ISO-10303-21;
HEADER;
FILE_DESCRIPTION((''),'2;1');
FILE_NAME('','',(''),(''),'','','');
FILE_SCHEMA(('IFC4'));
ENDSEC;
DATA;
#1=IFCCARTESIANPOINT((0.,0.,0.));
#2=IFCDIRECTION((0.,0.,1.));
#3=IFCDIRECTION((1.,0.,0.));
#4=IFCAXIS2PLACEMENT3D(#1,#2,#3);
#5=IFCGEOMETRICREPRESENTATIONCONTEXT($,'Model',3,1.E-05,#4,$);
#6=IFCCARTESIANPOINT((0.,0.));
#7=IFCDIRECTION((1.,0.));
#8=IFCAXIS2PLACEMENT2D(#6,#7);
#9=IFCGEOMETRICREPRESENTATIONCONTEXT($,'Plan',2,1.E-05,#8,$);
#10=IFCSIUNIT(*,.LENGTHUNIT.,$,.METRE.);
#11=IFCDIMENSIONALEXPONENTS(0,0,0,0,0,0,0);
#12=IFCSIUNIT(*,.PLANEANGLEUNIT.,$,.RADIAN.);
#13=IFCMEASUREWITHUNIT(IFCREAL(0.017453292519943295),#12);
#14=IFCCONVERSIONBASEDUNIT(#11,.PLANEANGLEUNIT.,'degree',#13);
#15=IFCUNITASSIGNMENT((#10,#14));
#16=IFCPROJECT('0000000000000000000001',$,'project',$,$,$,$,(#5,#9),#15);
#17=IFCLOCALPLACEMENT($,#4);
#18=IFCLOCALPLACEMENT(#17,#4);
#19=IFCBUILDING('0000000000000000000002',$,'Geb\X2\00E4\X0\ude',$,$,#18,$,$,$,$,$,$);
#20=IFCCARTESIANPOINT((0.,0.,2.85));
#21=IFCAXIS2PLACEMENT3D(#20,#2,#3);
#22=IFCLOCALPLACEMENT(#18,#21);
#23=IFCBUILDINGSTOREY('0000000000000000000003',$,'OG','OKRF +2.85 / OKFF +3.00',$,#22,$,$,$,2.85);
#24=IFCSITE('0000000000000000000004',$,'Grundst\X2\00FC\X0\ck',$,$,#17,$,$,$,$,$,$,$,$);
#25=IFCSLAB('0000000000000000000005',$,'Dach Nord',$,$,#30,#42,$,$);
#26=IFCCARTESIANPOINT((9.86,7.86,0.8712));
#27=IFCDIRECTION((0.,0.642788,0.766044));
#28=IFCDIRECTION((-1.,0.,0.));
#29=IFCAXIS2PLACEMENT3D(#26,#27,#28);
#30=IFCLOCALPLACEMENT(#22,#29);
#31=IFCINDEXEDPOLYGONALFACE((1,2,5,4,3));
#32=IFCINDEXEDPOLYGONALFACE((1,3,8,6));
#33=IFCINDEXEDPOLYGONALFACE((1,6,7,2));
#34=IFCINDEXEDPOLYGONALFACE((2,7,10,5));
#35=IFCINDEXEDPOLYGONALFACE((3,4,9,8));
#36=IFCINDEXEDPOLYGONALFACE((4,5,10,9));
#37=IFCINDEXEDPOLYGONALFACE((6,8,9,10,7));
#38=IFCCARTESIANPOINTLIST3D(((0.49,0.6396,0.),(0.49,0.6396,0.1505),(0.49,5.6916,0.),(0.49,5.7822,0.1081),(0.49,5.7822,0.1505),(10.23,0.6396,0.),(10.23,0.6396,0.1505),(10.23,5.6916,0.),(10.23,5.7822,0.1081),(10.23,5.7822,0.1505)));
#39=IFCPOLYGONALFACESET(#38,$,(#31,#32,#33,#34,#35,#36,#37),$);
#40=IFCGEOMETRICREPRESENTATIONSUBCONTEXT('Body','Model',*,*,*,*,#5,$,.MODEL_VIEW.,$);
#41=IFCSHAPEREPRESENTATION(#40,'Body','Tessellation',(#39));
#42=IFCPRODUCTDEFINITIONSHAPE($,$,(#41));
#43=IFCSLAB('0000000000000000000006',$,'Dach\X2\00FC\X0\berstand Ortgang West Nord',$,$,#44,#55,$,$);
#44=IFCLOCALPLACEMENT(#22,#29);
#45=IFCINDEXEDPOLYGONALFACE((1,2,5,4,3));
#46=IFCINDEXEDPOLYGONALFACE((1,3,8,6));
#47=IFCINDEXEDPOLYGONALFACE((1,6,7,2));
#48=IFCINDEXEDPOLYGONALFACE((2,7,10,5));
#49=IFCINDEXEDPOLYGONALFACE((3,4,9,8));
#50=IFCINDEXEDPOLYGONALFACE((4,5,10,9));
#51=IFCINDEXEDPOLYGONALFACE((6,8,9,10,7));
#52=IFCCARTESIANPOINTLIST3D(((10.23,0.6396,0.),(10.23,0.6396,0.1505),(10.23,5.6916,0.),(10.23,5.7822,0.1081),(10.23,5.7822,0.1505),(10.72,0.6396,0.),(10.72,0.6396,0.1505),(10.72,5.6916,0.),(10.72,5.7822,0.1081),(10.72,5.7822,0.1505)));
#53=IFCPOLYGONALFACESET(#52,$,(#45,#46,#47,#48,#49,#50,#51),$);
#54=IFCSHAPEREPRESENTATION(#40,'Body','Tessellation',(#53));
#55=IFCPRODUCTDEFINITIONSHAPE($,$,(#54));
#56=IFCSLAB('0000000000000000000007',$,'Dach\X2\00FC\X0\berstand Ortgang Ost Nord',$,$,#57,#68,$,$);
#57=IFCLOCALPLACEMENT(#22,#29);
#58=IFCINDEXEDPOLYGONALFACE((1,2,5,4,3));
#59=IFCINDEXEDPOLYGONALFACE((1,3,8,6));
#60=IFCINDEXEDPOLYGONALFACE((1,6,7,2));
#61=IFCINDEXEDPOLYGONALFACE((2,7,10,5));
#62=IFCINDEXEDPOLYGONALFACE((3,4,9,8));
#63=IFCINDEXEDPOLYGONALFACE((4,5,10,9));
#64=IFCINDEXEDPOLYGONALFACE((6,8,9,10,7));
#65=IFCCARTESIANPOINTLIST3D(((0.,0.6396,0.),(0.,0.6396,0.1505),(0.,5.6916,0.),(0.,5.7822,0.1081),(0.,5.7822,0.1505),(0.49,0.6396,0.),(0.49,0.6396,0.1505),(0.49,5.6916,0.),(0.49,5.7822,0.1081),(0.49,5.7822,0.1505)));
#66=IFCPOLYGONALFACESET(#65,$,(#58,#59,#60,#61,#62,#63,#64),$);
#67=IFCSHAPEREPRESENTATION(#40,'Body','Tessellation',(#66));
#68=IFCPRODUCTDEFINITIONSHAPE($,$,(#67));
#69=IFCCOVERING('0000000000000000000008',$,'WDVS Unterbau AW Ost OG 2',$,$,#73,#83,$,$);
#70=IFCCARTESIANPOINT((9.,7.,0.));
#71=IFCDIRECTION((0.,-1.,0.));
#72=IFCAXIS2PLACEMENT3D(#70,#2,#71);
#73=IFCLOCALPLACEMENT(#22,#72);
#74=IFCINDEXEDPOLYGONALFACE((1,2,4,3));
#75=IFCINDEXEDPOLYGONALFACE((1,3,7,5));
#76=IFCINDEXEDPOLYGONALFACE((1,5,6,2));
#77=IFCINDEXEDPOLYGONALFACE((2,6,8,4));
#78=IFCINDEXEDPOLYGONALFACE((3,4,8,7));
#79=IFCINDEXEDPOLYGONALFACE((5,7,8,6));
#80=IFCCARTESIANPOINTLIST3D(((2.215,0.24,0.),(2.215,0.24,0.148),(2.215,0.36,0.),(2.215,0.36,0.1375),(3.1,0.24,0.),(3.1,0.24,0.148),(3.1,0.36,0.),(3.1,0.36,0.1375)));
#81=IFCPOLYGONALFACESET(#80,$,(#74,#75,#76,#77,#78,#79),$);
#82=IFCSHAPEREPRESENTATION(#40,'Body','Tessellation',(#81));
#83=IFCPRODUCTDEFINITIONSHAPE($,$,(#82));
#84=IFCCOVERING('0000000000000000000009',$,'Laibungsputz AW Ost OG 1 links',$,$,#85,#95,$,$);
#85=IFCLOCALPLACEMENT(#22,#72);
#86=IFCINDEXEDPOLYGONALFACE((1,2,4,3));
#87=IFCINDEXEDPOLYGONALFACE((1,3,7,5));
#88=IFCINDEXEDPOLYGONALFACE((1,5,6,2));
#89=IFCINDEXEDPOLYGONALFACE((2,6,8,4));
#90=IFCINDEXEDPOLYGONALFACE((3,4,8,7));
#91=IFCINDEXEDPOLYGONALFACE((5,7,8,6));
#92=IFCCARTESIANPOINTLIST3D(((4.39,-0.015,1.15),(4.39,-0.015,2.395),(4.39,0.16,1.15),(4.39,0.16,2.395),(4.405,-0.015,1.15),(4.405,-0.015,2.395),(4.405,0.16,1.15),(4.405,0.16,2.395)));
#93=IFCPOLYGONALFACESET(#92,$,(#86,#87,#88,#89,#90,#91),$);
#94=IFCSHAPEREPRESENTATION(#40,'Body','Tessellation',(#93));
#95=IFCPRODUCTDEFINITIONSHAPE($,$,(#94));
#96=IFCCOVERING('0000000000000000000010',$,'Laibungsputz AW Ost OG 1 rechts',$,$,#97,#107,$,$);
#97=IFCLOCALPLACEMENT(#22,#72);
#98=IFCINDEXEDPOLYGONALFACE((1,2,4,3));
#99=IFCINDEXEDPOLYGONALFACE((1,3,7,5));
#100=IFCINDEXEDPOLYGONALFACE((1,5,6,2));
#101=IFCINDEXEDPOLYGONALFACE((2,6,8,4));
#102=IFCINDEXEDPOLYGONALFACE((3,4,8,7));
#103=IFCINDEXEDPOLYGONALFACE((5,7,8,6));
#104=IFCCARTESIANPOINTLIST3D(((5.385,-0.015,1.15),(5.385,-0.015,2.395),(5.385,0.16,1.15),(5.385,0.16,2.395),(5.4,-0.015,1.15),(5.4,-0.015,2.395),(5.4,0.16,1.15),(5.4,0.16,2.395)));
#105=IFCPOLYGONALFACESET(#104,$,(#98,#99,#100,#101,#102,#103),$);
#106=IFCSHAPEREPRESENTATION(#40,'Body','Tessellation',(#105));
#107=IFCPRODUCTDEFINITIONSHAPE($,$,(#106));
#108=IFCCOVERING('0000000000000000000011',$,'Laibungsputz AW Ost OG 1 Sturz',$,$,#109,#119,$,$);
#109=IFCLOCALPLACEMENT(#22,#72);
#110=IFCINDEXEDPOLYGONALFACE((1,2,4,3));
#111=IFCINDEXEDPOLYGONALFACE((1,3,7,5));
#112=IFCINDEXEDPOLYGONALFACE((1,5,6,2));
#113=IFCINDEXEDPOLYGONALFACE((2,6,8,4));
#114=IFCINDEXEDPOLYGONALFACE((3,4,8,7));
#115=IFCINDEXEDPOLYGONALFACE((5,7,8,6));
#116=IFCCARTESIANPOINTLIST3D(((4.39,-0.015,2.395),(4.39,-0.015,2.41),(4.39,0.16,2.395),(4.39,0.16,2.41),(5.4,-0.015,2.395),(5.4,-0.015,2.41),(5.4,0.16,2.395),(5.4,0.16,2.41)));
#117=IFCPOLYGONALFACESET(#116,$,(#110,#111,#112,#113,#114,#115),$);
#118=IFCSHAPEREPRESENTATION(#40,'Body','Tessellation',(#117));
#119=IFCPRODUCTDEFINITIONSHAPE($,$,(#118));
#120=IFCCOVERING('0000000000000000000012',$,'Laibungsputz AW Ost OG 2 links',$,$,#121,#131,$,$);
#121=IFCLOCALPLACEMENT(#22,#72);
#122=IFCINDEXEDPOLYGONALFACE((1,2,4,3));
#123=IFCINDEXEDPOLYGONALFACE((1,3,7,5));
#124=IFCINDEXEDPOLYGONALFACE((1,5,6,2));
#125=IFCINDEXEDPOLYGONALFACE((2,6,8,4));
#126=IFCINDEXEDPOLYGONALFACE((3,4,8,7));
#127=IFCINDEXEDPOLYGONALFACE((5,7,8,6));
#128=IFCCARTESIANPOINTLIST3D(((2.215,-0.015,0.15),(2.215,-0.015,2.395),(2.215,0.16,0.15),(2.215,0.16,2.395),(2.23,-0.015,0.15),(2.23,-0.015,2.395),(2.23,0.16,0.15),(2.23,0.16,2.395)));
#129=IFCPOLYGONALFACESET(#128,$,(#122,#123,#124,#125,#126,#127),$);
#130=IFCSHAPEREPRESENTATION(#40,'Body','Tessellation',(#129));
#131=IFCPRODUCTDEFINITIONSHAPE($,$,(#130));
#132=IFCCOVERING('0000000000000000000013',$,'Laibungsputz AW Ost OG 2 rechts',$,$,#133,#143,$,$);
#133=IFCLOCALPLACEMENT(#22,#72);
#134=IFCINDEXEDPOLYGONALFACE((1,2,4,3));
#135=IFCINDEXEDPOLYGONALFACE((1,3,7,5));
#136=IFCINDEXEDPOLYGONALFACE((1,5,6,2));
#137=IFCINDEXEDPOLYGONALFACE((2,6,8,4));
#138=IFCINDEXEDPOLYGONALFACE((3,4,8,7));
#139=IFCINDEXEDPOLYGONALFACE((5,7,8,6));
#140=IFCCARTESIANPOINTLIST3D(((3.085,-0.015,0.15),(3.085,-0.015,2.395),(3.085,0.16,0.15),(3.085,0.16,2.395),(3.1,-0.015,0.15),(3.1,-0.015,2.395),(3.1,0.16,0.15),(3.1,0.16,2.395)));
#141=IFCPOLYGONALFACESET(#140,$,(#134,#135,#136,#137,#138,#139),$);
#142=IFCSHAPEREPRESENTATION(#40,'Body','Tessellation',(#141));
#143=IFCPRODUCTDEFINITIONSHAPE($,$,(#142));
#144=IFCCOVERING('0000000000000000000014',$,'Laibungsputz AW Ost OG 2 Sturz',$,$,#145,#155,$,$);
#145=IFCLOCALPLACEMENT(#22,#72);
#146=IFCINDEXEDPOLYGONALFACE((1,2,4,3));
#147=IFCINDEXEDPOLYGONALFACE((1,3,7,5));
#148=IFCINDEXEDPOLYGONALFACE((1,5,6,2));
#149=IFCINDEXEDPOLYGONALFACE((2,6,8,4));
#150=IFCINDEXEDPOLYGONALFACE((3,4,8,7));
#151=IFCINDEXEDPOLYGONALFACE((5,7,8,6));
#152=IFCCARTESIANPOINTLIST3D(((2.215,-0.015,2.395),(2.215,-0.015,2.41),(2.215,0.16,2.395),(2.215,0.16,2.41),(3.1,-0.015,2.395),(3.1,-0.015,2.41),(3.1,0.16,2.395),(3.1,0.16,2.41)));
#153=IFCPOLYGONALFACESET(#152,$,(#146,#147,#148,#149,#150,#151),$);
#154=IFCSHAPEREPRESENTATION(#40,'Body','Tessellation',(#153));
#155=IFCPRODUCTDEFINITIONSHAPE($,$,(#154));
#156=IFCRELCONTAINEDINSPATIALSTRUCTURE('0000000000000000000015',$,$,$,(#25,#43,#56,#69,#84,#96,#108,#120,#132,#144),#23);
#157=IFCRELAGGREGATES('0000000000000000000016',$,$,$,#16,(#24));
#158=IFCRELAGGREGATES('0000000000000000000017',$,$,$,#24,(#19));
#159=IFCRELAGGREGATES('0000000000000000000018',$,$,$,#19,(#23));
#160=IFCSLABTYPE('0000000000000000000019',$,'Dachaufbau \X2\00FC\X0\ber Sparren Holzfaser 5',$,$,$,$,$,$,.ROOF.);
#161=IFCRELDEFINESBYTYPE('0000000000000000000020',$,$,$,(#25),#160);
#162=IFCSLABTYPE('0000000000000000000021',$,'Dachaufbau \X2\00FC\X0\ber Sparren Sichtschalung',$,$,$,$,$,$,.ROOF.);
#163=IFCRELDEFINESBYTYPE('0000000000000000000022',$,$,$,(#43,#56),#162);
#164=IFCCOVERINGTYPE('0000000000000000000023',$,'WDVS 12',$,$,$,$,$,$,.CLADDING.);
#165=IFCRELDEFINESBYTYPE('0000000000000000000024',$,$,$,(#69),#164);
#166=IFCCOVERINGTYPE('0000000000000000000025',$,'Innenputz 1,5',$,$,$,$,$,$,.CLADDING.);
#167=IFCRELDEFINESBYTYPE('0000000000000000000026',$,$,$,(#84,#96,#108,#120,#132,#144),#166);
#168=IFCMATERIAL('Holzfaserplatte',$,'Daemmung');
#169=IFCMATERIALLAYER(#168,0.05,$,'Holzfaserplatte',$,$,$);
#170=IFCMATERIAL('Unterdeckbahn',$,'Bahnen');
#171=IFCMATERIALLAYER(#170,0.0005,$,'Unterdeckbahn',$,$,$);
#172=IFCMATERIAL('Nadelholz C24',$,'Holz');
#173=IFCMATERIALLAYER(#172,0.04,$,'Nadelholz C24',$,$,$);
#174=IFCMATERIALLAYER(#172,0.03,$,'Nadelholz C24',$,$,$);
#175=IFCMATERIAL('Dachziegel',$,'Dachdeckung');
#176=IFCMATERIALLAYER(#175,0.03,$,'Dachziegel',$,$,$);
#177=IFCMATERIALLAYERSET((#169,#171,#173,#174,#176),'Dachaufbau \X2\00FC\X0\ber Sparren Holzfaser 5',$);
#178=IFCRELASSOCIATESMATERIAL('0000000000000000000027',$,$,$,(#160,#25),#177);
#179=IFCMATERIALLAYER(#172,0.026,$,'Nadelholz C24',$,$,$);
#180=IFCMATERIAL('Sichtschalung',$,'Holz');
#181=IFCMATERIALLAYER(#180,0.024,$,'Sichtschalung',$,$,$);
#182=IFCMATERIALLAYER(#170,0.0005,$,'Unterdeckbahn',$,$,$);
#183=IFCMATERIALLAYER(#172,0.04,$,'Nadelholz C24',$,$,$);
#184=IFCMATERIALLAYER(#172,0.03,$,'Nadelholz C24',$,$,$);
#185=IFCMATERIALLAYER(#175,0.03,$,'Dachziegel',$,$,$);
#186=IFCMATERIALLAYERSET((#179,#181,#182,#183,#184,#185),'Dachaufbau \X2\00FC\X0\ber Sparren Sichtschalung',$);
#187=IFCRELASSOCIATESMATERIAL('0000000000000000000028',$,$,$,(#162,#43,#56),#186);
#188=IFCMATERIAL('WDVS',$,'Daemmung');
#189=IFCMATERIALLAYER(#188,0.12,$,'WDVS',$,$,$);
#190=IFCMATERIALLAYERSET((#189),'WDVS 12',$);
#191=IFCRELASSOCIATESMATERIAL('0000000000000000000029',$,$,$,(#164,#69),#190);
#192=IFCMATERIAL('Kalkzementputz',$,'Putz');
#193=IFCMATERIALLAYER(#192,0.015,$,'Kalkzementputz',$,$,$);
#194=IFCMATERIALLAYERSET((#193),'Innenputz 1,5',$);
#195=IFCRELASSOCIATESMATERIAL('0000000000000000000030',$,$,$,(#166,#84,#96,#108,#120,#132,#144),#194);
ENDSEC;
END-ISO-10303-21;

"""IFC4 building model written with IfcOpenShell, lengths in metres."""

from ifc_helpers import new_model, entity, si_unit, converted_unit, frame, origin_with_axes, origin_2d_with_axis, place, context, subcontext, project, spatial, polyline, indexed_curve, outline, extrude, clip, halfspace, material, layer, layer_set, layer_usage, type_object, element, save


model = new_model("IFC4")

# Units and contexts
model_context = context("Model", 3, precision=1e-05, world=origin_with_axes())
plan_context = context("Plan", 2, precision=1e-05, world=origin_2d_with_axis())
body_context = subcontext(model_context, "Body", "Model", "MODEL_VIEW")
ifc_project = project(units=[si_unit("LENGTHUNIT", "METRE"), converted_unit("PLANEANGLEUNIT", "degree", entity("IfcReal", 0.017453292519943295), si_unit("PLANEANGLEUNIT", "RADIAN"), dimensions=[0, 0, 0, 0, 0, 0, 0])], contexts=[model_context, plan_context])

# Site, building, storey
site_placement = place(None, origin_with_axes())
site = spatial("IfcSite", under=ifc_project, at=site_placement, Name="Grundstück")
building_placement = place(site_placement, origin_with_axes())
building = spatial("IfcBuilding", under=site, at=building_placement, Name="Gebäude")
storey_placement = place(building_placement, frame((0.0, 0.0, 2.85), z_axis=(0.0, 0.0, 1.0), x_axis=(1.0, 0.0, 0.0)))
storey = spatial("IfcBuildingStorey", under=building, at=storey_placement, Name="OG", Description="OKRF +2.85 / OKFF +3.00", Elevation=2.85)

# Shared definitions
ifc_material_1 = material(Name="Nadelholz C24", Category="Holz")

# Slabs
ifc_material_2 = material(Name="Holzfaserplatte", Category="Daemmung")
ifc_layer_1 = layer(ifc_material_2, 0.05, Name="Holzfaserplatte")
ifc_material_3 = material(Name="Unterdeckbahn", Category="Bahnen")
ifc_layer_2 = layer(ifc_material_3, 0.0005, Name="Unterdeckbahn")
ifc_layer_3 = layer(ifc_material_1, 0.04, Name="Nadelholz C24")
ifc_layer_4 = layer(ifc_material_1, 0.03, Name="Nadelholz C24")
ifc_material_4 = material(Name="Dachziegel", Category="Dachdeckung")
ifc_layer_5 = layer(ifc_material_4, 0.03, Name="Dachziegel")
ifc_layer_set_1 = layer_set([ifc_layer_1, ifc_layer_2, ifc_layer_3, ifc_layer_4, ifc_layer_5], Name="Dachaufbau über Sparren Holzfaser 5")
ifc_layer_usage_1 = layer_usage(ifc_layer_set_1, "AXIS3", "POSITIVE", 0.0)
slab_type_1 = type_object("IfcSlabType", Name="Dachaufbau über Sparren Holzfaser 5", PredefinedType="ROOF", material=ifc_layer_set_1)
slab_1_placement = place(storey_placement, frame((9.86, 7.86, 0.8712), z_axis=(0.0, 0.642788, 0.766044), x_axis=(-1.0, 0.0, 0.0)))
element("IfcSlab", 1, at=slab_1_placement, inside=storey, type_object=slab_type_1, material=ifc_layer_usage_1, Name="Dach Nord", context=body_context, shape_type="Clipping", body=[
    clip(extrude(outline(indexed_curve([(10.23, 5.7822), (0.49, 5.7822), (0.49, 0.6396), (10.23, 0.6396)])), None, (0.0, 0.0, 1.0), 0.1505), halfspace(frame((9.86, 0.948, -5.6532), z_axis=(0.0, 0.766044, -0.642788), x_axis=(1.0, 0.0, 0.0)), False)),
])
ifc_layer_6 = layer(ifc_material_1, 0.026, Name="Nadelholz C24")
ifc_material_5 = material(Name="Sichtschalung", Category="Holz")
ifc_layer_7 = layer(ifc_material_5, 0.024, Name="Sichtschalung")
ifc_layer_8 = layer(ifc_material_3, 0.0005, Name="Unterdeckbahn")
ifc_layer_9 = layer(ifc_material_1, 0.04, Name="Nadelholz C24")
ifc_layer_10 = layer(ifc_material_1, 0.03, Name="Nadelholz C24")
ifc_layer_11 = layer(ifc_material_4, 0.03, Name="Dachziegel")
ifc_layer_set_2 = layer_set([ifc_layer_6, ifc_layer_7, ifc_layer_8, ifc_layer_9, ifc_layer_10, ifc_layer_11], Name="Dachaufbau über Sparren Sichtschalung")
slab_type_2 = type_object("IfcSlabType", Name="Dachaufbau über Sparren Sichtschalung", PredefinedType="ROOF", material=ifc_layer_set_2)
ifc_layer_usage_2 = layer_usage(ifc_layer_set_2, "AXIS3", "POSITIVE", 0.0)
slab_2_placement = place(storey_placement, frame((9.86, 7.86, 0.8712), z_axis=(0.0, 0.642788, 0.766044), x_axis=(-1.0, 0.0, 0.0)))
element("IfcSlab", 2, at=slab_2_placement, inside=storey, type_object=slab_type_2, material=ifc_layer_usage_2, Name="Dachüberstand Ortgang West Nord", context=body_context, shape_type="Clipping", body=[
    clip(extrude(outline(indexed_curve([(10.72, 5.7822), (10.23, 5.7822), (10.23, 0.6396), (10.72, 0.6396)])), None, (0.0, 0.0, 1.0), 0.1505), halfspace(frame((9.86, 0.948, -5.6532), z_axis=(0.0, 0.766044, -0.642788), x_axis=(1.0, 0.0, 0.0)), False)),
])
ifc_layer_usage_3 = layer_usage(ifc_layer_set_2, "AXIS3", "POSITIVE", 0.0)
slab_3_placement = place(storey_placement, frame((9.86, 7.86, 0.8712), z_axis=(0.0, 0.642788, 0.766044), x_axis=(-1.0, 0.0, 0.0)))
element("IfcSlab", 3, at=slab_3_placement, inside=storey, type_object=slab_type_2, material=ifc_layer_usage_3, Name="Dachüberstand Ortgang Ost Nord", context=body_context, shape_type="Clipping", body=[
    clip(extrude(outline(indexed_curve([(0.49, 5.7822), (0.0, 5.7822), (0.0, 0.6396), (0.49, 0.6396)])), None, (0.0, 0.0, 1.0), 0.1505), halfspace(frame((9.86, 0.948, -5.6532), z_axis=(0.0, 0.766044, -0.642788), x_axis=(1.0, 0.0, 0.0)), False)),
])

# Coverings
ifc_material_6 = material(Name="WDVS", Category="Daemmung")
ifc_layer_12 = layer(ifc_material_6, 0.12, Name="WDVS")
ifc_layer_set_3 = layer_set([ifc_layer_12], Name="WDVS 12")
ifc_layer_usage_4 = layer_usage(ifc_layer_set_3, "AXIS2", "POSITIVE", 0.24)
covering_type_1 = type_object("IfcCoveringType", Name="WDVS 12", PredefinedType="CLADDING", material=ifc_layer_set_3)
covering_1_placement = place(storey_placement, frame((9.0, 7.0, 0.0), z_axis=(0.0, 0.0, 1.0), x_axis=(0.0, -1.0, 0.0)))
element("IfcCovering", 4, at=covering_1_placement, inside=storey, type_object=covering_type_1, material=ifc_layer_usage_4, Name="WDVS Unterbau AW Ost OG 2", context=body_context, shape_type="SweptSolid", body=[
    extrude(outline(polyline([(0.24, 0.0), (0.36, 0.0), (0.36, 0.1375), (0.24, 0.148), (0.24, 0.0)])), frame((2.215, 0.0, 0.0), z_axis=(1.0, 0.0, 0.0), x_axis=(0.0, 1.0, 0.0)), (0.0, 0.0, 1.0), 0.885),
])
ifc_material_7 = material(Name="Kalkzementputz", Category="Putz")
ifc_layer_13 = layer(ifc_material_7, 0.015, Name="Kalkzementputz")
ifc_layer_set_4 = layer_set([ifc_layer_13], Name="Innenputz 1,5")
ifc_layer_usage_5 = layer_usage(ifc_layer_set_4, "AXIS1", "POSITIVE", 4.39)
covering_type_2 = type_object("IfcCoveringType", Name="Innenputz 1,5", PredefinedType="CLADDING", material=ifc_layer_set_4)
covering_2_placement = place(storey_placement, frame((9.0, 7.0, 0.0), z_axis=(0.0, 0.0, 1.0), x_axis=(0.0, -1.0, 0.0)))
element("IfcCovering", 5, at=covering_2_placement, inside=storey, type_object=covering_type_2, material=ifc_layer_usage_5, Name="Laibungsputz AW Ost OG 1 links", context=body_context, shape_type="SweptSolid", body=[
    extrude(outline(polyline([(-0.015, 1.15), (0.16, 1.15), (0.16, 2.395), (-0.015, 2.395), (-0.015, 1.15)])), frame((4.39, 0.0, 0.0), z_axis=(1.0, 0.0, 0.0), x_axis=(0.0, 1.0, 0.0)), (0.0, 0.0, 1.0), 0.015),
])
ifc_layer_usage_6 = layer_usage(ifc_layer_set_4, "AXIS1", "POSITIVE", 5.385)
covering_3_placement = place(storey_placement, frame((9.0, 7.0, 0.0), z_axis=(0.0, 0.0, 1.0), x_axis=(0.0, -1.0, 0.0)))
element("IfcCovering", 6, at=covering_3_placement, inside=storey, type_object=covering_type_2, material=ifc_layer_usage_6, Name="Laibungsputz AW Ost OG 1 rechts", context=body_context, shape_type="SweptSolid", body=[
    extrude(outline(polyline([(-0.015, 1.15), (0.16, 1.15), (0.16, 2.395), (-0.015, 2.395), (-0.015, 1.15)])), frame((5.385, 0.0, 0.0), z_axis=(1.0, 0.0, 0.0), x_axis=(0.0, 1.0, 0.0)), (0.0, 0.0, 1.0), 0.015),
])
ifc_layer_usage_7 = layer_usage(ifc_layer_set_4, "AXIS3", "POSITIVE", 2.395)
covering_4_placement = place(storey_placement, frame((9.0, 7.0, 0.0), z_axis=(0.0, 0.0, 1.0), x_axis=(0.0, -1.0, 0.0)))
element("IfcCovering", 7, at=covering_4_placement, inside=storey, type_object=covering_type_2, material=ifc_layer_usage_7, Name="Laibungsputz AW Ost OG 1 Sturz", context=body_context, shape_type="SweptSolid", body=[
    extrude(outline(polyline([(-0.015, 2.395), (0.16, 2.395), (0.16, 2.41), (-0.015, 2.41), (-0.015, 2.395)])), frame((4.39, 0.0, 0.0), z_axis=(1.0, 0.0, 0.0), x_axis=(0.0, 1.0, 0.0)), (0.0, 0.0, 1.0), 1.01),
])
ifc_layer_usage_8 = layer_usage(ifc_layer_set_4, "AXIS1", "POSITIVE", 2.215)
covering_5_placement = place(storey_placement, frame((9.0, 7.0, 0.0), z_axis=(0.0, 0.0, 1.0), x_axis=(0.0, -1.0, 0.0)))
element("IfcCovering", 8, at=covering_5_placement, inside=storey, type_object=covering_type_2, material=ifc_layer_usage_8, Name="Laibungsputz AW Ost OG 2 links", context=body_context, shape_type="SweptSolid", body=[
    extrude(outline(polyline([(-0.015, 0.15), (0.16, 0.15), (0.16, 2.395), (-0.015, 2.395), (-0.015, 0.15)])), frame((2.215, 0.0, 0.0), z_axis=(1.0, 0.0, 0.0), x_axis=(0.0, 1.0, 0.0)), (0.0, 0.0, 1.0), 0.015),
])
ifc_layer_usage_9 = layer_usage(ifc_layer_set_4, "AXIS1", "POSITIVE", 3.085)
covering_6_placement = place(storey_placement, frame((9.0, 7.0, 0.0), z_axis=(0.0, 0.0, 1.0), x_axis=(0.0, -1.0, 0.0)))
element("IfcCovering", 9, at=covering_6_placement, inside=storey, type_object=covering_type_2, material=ifc_layer_usage_9, Name="Laibungsputz AW Ost OG 2 rechts", context=body_context, shape_type="SweptSolid", body=[
    extrude(outline(polyline([(-0.015, 0.15), (0.16, 0.15), (0.16, 2.395), (-0.015, 2.395), (-0.015, 0.15)])), frame((3.085, 0.0, 0.0), z_axis=(1.0, 0.0, 0.0), x_axis=(0.0, 1.0, 0.0)), (0.0, 0.0, 1.0), 0.015),
])
ifc_layer_usage_10 = layer_usage(ifc_layer_set_4, "AXIS3", "POSITIVE", 2.395)
covering_7_placement = place(storey_placement, frame((9.0, 7.0, 0.0), z_axis=(0.0, 0.0, 1.0), x_axis=(0.0, -1.0, 0.0)))
element("IfcCovering", 10, at=covering_7_placement, inside=storey, type_object=covering_type_2, material=ifc_layer_usage_10, Name="Laibungsputz AW Ost OG 2 Sturz", context=body_context, shape_type="SweptSolid", body=[
    extrude(outline(polyline([(-0.015, 2.395), (0.16, 2.395), (0.16, 2.41), (-0.015, 2.41), (-0.015, 2.395)])), frame((2.215, 0.0, 0.0), z_axis=(1.0, 0.0, 0.0), x_axis=(0.0, 1.0, 0.0)), (0.0, 0.0, 1.0), 0.885),
])

save(model, "model.ifc")
